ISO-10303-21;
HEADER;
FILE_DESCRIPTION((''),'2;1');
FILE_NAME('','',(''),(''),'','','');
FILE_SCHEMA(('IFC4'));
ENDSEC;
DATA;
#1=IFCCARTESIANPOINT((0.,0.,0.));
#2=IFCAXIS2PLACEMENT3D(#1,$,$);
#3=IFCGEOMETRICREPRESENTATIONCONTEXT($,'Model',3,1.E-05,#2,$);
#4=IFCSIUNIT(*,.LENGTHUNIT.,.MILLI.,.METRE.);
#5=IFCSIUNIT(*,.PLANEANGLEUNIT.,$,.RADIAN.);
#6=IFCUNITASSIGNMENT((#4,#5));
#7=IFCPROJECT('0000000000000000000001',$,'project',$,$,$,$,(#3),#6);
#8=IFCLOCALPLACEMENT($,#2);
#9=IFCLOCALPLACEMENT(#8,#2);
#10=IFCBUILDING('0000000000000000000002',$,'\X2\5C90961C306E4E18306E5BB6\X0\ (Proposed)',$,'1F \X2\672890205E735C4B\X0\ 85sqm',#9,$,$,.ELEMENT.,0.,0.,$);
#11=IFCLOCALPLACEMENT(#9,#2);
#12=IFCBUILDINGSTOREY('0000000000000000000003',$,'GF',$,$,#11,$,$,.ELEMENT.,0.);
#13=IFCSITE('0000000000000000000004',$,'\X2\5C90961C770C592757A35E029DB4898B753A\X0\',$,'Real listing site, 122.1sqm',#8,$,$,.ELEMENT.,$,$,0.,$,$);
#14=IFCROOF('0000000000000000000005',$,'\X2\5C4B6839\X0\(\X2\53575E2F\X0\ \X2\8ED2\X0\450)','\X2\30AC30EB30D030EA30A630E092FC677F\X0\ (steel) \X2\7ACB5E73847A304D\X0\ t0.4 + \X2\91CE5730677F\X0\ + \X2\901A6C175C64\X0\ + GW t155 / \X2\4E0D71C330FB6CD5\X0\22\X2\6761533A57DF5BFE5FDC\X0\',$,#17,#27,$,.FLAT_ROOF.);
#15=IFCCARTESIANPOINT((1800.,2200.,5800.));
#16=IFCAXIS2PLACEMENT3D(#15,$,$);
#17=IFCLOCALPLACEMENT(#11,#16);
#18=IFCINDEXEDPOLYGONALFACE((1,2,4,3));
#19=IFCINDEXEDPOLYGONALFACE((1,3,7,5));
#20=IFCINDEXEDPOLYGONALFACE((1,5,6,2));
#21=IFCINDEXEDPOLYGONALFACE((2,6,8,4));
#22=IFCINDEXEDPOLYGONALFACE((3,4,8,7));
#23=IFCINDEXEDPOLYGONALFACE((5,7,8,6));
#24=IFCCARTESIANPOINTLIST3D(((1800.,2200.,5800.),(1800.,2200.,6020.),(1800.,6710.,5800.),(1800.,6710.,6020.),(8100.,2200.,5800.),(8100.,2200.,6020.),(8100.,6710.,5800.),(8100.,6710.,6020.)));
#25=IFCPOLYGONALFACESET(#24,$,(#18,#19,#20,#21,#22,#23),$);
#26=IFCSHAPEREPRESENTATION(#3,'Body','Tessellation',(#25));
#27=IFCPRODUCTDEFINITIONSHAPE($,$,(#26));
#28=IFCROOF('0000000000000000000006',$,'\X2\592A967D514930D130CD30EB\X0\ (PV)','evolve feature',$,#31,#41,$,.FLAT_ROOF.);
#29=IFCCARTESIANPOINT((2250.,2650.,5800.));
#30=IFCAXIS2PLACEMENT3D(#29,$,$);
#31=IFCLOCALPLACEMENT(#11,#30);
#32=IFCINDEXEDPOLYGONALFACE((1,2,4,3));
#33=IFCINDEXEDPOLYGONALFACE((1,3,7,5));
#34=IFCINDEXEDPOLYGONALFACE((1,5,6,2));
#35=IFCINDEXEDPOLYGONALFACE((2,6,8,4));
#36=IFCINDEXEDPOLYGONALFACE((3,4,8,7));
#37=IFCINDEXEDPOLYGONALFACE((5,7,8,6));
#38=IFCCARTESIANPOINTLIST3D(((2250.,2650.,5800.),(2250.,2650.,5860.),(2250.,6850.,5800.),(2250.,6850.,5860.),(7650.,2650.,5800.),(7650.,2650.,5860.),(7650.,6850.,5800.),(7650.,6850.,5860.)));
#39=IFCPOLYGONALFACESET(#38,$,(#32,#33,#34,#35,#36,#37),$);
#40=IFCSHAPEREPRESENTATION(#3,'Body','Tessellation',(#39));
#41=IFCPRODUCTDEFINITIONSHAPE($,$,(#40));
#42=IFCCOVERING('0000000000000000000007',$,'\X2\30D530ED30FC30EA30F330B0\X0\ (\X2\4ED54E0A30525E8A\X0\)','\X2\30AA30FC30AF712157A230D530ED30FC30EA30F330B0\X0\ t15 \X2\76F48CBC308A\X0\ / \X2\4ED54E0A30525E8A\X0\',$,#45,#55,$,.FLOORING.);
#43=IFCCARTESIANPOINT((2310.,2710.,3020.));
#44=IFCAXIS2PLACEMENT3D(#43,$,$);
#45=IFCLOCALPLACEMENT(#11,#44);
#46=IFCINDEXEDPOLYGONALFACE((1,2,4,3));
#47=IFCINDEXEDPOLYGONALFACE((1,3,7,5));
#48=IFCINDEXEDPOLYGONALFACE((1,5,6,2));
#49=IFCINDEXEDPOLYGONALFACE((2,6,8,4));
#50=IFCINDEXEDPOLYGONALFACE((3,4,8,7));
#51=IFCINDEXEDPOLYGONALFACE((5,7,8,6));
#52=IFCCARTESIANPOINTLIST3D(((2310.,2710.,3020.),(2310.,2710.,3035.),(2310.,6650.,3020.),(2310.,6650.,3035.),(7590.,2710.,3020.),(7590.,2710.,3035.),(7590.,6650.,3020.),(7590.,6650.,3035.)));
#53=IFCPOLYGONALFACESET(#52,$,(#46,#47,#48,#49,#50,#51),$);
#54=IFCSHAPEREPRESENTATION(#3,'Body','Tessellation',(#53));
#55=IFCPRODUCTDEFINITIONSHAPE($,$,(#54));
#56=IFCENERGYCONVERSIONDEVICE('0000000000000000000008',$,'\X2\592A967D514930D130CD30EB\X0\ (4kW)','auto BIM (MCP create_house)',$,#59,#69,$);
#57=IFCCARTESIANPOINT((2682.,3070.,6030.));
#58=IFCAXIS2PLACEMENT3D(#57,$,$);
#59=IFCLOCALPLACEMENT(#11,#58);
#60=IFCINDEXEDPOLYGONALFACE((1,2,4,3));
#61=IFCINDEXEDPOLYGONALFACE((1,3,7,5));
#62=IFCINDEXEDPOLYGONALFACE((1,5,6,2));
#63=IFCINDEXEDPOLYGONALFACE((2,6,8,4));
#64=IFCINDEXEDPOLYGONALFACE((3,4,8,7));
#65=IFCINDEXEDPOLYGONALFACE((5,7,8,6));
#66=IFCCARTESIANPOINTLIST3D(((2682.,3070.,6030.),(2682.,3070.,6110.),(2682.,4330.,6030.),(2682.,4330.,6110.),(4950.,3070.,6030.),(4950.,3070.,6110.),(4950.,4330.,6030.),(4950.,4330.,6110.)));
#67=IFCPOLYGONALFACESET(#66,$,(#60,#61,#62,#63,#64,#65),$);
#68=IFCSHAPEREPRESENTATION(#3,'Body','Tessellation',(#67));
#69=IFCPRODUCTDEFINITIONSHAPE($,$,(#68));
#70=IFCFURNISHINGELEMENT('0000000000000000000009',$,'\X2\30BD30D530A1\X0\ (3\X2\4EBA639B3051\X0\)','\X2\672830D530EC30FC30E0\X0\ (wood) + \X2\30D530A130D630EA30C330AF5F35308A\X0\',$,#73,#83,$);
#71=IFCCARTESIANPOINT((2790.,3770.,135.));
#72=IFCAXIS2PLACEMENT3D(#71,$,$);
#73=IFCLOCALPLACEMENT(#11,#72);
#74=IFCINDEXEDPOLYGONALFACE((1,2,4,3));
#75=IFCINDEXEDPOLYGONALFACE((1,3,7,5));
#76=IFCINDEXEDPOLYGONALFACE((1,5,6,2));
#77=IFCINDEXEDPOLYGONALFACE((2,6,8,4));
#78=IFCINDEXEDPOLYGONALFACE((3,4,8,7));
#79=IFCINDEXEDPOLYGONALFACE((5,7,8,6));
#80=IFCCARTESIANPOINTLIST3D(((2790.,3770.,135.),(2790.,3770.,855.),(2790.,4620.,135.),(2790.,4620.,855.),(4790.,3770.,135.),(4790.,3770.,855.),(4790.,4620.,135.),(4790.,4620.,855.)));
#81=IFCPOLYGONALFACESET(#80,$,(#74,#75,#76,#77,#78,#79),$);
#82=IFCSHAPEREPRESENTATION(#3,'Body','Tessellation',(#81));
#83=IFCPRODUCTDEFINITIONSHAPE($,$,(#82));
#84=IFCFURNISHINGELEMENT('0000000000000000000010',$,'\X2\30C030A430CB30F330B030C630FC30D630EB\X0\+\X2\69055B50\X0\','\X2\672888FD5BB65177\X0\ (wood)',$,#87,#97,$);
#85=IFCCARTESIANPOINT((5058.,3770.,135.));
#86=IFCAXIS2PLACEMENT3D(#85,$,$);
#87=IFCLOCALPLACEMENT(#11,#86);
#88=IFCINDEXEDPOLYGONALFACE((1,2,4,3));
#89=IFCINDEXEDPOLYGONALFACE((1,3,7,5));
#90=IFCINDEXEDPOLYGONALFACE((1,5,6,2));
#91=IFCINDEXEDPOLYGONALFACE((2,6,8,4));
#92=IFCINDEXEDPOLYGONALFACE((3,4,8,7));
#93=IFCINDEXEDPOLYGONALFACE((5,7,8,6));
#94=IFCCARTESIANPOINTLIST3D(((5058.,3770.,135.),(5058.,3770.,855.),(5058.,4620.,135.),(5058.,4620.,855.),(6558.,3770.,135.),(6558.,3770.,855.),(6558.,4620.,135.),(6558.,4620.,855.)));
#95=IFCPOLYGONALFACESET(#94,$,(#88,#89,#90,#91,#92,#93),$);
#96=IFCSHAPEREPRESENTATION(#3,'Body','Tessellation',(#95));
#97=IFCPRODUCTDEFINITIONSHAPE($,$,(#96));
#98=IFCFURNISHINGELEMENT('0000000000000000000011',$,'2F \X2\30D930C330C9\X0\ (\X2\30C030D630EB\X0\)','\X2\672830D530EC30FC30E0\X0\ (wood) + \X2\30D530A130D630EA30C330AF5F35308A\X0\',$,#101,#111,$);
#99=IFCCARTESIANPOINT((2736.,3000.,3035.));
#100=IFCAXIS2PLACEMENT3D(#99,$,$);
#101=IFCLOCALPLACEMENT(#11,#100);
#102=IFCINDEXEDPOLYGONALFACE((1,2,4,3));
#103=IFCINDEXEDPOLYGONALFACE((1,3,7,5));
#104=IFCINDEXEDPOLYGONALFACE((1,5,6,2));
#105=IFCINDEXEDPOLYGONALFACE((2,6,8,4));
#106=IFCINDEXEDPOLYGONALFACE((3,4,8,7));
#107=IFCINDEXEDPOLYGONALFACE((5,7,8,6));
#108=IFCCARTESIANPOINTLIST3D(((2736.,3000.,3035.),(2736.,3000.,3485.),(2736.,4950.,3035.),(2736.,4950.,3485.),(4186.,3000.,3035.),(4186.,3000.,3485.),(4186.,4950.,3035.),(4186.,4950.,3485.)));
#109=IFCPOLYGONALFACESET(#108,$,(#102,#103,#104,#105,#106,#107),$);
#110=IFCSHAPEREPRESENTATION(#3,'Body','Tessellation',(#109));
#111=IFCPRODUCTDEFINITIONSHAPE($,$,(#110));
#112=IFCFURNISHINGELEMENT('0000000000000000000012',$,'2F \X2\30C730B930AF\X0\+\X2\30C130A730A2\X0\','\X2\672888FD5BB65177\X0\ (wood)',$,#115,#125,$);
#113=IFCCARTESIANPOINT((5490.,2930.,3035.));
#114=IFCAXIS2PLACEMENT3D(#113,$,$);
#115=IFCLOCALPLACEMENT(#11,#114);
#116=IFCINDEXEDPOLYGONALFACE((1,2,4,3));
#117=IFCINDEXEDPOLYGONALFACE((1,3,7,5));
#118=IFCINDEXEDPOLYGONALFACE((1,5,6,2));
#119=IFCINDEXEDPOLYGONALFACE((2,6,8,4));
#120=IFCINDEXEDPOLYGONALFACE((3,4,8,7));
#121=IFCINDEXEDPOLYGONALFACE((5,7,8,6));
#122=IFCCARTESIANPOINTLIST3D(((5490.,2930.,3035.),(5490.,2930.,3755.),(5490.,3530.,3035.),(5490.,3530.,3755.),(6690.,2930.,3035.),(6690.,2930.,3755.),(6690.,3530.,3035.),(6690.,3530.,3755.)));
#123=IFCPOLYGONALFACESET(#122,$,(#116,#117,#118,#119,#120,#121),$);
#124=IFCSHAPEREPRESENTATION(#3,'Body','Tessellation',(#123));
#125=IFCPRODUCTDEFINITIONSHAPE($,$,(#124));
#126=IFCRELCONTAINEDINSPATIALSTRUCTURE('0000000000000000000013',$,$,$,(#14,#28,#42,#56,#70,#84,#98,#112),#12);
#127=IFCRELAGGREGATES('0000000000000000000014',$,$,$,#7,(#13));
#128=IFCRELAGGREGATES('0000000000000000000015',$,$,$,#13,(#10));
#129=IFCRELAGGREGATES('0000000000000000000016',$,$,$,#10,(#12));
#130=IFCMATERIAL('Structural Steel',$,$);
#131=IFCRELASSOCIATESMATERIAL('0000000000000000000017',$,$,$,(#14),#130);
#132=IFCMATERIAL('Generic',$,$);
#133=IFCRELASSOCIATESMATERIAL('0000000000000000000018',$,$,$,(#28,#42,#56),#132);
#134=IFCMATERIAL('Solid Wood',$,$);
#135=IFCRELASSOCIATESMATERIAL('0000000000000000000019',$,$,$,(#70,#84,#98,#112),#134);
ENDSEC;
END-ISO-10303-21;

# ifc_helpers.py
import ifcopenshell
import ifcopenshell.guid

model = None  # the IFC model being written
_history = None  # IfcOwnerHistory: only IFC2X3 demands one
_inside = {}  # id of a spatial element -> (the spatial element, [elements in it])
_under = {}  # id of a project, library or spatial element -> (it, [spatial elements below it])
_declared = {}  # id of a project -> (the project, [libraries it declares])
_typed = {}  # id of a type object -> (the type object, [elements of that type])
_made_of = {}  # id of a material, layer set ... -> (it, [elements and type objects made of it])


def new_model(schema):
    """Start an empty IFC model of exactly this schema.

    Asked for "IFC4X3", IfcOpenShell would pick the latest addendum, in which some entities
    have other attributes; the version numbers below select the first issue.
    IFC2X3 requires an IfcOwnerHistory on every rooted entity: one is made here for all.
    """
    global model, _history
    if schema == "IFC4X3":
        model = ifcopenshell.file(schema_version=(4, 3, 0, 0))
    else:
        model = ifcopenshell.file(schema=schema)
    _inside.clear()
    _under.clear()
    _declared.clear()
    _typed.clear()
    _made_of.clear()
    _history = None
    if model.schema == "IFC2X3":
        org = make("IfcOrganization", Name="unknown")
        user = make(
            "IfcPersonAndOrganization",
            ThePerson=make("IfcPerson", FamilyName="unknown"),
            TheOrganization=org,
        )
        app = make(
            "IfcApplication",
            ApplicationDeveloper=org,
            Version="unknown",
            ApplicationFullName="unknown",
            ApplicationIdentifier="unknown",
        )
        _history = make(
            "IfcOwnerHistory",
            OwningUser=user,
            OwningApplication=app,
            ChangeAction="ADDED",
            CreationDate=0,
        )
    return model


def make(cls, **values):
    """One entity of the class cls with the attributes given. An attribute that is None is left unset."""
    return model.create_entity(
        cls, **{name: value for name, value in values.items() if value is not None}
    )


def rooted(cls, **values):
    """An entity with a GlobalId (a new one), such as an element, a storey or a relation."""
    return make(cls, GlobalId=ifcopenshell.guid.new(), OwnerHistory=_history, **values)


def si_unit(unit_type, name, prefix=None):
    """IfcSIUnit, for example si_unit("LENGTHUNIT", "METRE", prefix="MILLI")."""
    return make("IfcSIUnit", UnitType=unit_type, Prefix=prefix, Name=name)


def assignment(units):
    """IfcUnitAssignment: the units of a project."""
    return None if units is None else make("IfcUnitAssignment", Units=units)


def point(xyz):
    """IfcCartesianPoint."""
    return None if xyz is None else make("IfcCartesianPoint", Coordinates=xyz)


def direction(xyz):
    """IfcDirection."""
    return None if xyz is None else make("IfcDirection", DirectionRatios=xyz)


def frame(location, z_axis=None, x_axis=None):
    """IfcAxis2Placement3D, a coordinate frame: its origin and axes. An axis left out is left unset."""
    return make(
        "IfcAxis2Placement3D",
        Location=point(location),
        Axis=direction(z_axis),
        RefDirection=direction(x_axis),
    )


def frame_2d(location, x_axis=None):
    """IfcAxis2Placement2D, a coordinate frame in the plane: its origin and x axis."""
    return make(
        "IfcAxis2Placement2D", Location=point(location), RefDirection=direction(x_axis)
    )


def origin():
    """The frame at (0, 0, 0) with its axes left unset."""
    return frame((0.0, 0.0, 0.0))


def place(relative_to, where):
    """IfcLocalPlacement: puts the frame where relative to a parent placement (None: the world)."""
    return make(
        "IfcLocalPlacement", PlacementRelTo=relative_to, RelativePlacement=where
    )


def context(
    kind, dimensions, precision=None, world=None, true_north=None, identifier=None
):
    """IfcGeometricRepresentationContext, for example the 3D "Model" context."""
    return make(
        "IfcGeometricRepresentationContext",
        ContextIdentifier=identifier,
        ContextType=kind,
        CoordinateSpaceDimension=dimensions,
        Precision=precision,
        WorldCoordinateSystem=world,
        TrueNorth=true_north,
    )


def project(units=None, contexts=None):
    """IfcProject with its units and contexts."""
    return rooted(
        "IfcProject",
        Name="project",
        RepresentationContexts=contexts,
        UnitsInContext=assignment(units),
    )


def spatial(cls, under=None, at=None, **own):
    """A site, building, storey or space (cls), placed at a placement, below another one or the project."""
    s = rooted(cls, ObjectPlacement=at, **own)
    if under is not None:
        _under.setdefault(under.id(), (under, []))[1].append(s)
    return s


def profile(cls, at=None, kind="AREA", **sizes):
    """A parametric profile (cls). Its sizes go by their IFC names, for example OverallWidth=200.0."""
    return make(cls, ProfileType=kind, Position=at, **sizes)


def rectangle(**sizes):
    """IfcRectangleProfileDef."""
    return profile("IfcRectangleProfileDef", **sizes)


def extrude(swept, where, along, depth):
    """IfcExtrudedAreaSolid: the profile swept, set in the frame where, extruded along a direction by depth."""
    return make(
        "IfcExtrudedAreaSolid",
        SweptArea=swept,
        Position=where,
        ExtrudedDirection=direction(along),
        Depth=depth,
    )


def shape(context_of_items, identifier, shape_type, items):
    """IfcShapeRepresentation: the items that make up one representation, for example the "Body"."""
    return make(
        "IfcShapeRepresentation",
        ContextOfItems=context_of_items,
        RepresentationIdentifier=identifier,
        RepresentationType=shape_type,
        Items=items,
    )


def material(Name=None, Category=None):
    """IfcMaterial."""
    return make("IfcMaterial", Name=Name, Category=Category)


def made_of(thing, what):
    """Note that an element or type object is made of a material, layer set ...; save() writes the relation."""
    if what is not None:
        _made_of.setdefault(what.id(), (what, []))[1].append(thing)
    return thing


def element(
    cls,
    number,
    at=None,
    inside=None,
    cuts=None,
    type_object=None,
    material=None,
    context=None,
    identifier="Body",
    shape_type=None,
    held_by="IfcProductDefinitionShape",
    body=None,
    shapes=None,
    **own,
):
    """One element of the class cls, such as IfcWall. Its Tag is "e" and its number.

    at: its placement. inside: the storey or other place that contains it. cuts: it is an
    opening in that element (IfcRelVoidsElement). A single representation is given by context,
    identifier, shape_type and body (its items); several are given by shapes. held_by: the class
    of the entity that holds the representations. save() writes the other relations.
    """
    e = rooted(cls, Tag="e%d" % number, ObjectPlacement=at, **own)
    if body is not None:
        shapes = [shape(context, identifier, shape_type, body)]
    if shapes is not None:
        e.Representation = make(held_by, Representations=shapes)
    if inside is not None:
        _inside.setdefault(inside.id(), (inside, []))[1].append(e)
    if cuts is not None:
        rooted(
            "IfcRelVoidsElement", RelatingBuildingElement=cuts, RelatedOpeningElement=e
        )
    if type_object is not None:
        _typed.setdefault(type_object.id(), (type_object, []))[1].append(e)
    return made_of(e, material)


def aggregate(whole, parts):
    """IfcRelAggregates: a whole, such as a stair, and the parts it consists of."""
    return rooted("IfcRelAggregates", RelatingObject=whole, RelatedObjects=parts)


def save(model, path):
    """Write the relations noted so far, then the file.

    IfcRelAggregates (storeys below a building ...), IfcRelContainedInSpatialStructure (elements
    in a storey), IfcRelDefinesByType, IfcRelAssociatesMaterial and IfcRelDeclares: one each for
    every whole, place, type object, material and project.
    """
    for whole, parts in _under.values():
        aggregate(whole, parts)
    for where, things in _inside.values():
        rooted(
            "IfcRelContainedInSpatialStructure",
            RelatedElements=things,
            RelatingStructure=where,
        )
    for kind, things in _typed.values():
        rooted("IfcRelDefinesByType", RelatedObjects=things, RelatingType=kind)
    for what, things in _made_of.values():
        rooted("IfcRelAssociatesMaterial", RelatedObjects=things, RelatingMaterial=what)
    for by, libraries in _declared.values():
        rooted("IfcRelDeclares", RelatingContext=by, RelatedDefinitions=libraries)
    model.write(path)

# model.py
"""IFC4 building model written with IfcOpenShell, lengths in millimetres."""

from ifc_helpers import new_model, si_unit, frame, frame_2d, origin, place, context, project, spatial, rectangle, extrude, material, element, save


model = new_model("IFC4")

# Units and contexts
model_context = context("Model", 3, precision=1e-05, world=origin())
ifc_project = project(units=[si_unit("LENGTHUNIT", "METRE", prefix="MILLI"), si_unit("PLANEANGLEUNIT", "RADIAN")], contexts=[model_context])

# Site, building, storey
site_placement = place(None, origin())
site = spatial("IfcSite", under=ifc_project, at=site_placement, Name="岐阜県大垣市鶴見町", ObjectType="Real listing site, 122.1sqm", CompositionType="ELEMENT", RefElevation=0.0)
building_placement = place(site_placement, origin())
building = spatial("IfcBuilding", under=site, at=building_placement, Name="岐阜の丘の家 (Proposed)", ObjectType="1F 木造平屋 85sqm", CompositionType="ELEMENT", ElevationOfRefHeight=0.0, ElevationOfTerrain=0.0)
storey_placement = place(building_placement, origin())
storey = spatial("IfcBuildingStorey", under=building, at=storey_placement, Name="GF", CompositionType="ELEMENT", Elevation=0.0)

# Shared definitions
ifc_material_1 = material(Name="Solid Wood")

# Shared definitions
ifc_material_2 = material(Name="Generic")

# Roofs
ifc_material_3 = material(Name="Structural Steel")
for number, where, name in (
    (1, (1800.0, 2200.0, 5800.0), "屋根(南帯 軒450)"),
):
    element("IfcRoof", number, at=place(storey_placement, frame(where)), inside=storey, material=ifc_material_3, Name=name, Description="ガルバリウム鋼板 (steel) 立平葺き t0.4 + 野地板 + 通気層 + GW t155 / 不燃・法22条区域対応", PredefinedType="FLAT_ROOF", context=model_context, shape_type="SweptSolid", body=[
        extrude(rectangle(XDim=6300.0, YDim=4510.0, at=frame_2d((3150.0, 2255.0))), frame((1800.0, 2200.0, 5800.0)), (0.0, 0.0, 1.0), 220.0),
    ])
roof_placement = place(storey_placement, frame((2250.0, 2650.0, 5800.0)))
element("IfcRoof", 2, at=roof_placement, inside=storey, material=ifc_material_2, Name="太陽光パネル (PV)", Description="evolve feature", PredefinedType="FLAT_ROOF", context=model_context, shape_type="SweptSolid", body=[
    extrude(rectangle(XDim=5400.0, YDim=4200.0, at=frame_2d((2700.0, 2100.0))), frame((2250.0, 2650.0, 5800.0)), (0.0, 0.0, 1.0), 60.0),
])

# Covering
covering_placement = place(storey_placement, frame((2310.0, 2710.0, 3020.0)))
element("IfcCovering", 3, at=covering_placement, inside=storey, material=ifc_material_2, Name="フローリング (仕上げ床)", Description="オーク無垢フローリング t15 直貼り / 仕上げ床", PredefinedType="FLOORING", context=model_context, shape_type="SweptSolid", body=[
    extrude(rectangle(XDim=5280.0, YDim=3940.0, at=frame_2d((2640.0, 1970.0))), frame((2310.0, 2710.0, 3020.0)), (0.0, 0.0, 1.0), 15.0),
])

# Energy conversion device
energy_conversion_device_placement = place(storey_placement, frame((2682.0, 3070.0, 6030.0)))
element("IfcEnergyConversionDevice", 4, at=energy_conversion_device_placement, inside=storey, material=ifc_material_2, Name="太陽光パネル (4kW)", Description="auto BIM (MCP create_house)", context=model_context, shape_type="SweptSolid", body=[
    extrude(rectangle(XDim=2268.0, YDim=1260.0, at=frame_2d((1134.0, 630.0))), frame((2682.0, 3070.0, 6030.0)), (0.0, 0.0, 1.0), 80.0),
])

# Furnishing elements
furnishing_1_placement = place(storey_placement, frame((2790.0, 3770.0, 135.0)))
element("IfcFurnishingElement", 5, at=furnishing_1_placement, inside=storey, material=ifc_material_1, Name="ソファ (3人掛け)", Description="木フレーム (wood) + ファブリック張り", context=model_context, shape_type="SweptSolid", body=[
    extrude(rectangle(XDim=2000.0, YDim=850.0, at=frame_2d((1000.0, 425.0))), frame((2790.0, 3770.0, 135.0)), (0.0, 0.0, 1.0), 720.0),
])
furnishing_2_placement = place(storey_placement, frame((5058.0, 3770.0, 135.0)))
element("IfcFurnishingElement", 6, at=furnishing_2_placement, inside=storey, material=ifc_material_1, Name="ダイニングテーブル+椅子", Description="木製家具 (wood)", context=model_context, shape_type="SweptSolid", body=[
    extrude(rectangle(XDim=1500.0, YDim=850.0, at=frame_2d((750.0, 425.0))), frame((5058.0, 3770.0, 135.0)), (0.0, 0.0, 1.0), 720.0),
])
furnishing_3_placement = place(storey_placement, frame((2736.0, 3000.0, 3035.0)))
element("IfcFurnishingElement", 7, at=furnishing_3_placement, inside=storey, material=ifc_material_1, Name="2F ベッド (ダブル)", Description="木フレーム (wood) + ファブリック張り", context=model_context, shape_type="SweptSolid", body=[
    extrude(rectangle(XDim=1450.0, YDim=1950.0, at=frame_2d((725.0, 975.0))), frame((2736.0, 3000.0, 3035.0)), (0.0, 0.0, 1.0), 450.0),
])
furnishing_4_placement = place(storey_placement, frame((5490.0, 2930.0, 3035.0)))
element("IfcFurnishingElement", 8, at=furnishing_4_placement, inside=storey, material=ifc_material_1, Name="2F デスク+チェア", Description="木製家具 (wood)", context=model_context, shape_type="SweptSolid", body=[
    extrude(rectangle(XDim=1200.0, YDim=600.0, at=frame_2d((600.0, 300.0))), frame((5490.0, 2930.0, 3035.0)), (0.0, 0.0, 1.0), 720.0),
])

save(model, "model.ifc")
